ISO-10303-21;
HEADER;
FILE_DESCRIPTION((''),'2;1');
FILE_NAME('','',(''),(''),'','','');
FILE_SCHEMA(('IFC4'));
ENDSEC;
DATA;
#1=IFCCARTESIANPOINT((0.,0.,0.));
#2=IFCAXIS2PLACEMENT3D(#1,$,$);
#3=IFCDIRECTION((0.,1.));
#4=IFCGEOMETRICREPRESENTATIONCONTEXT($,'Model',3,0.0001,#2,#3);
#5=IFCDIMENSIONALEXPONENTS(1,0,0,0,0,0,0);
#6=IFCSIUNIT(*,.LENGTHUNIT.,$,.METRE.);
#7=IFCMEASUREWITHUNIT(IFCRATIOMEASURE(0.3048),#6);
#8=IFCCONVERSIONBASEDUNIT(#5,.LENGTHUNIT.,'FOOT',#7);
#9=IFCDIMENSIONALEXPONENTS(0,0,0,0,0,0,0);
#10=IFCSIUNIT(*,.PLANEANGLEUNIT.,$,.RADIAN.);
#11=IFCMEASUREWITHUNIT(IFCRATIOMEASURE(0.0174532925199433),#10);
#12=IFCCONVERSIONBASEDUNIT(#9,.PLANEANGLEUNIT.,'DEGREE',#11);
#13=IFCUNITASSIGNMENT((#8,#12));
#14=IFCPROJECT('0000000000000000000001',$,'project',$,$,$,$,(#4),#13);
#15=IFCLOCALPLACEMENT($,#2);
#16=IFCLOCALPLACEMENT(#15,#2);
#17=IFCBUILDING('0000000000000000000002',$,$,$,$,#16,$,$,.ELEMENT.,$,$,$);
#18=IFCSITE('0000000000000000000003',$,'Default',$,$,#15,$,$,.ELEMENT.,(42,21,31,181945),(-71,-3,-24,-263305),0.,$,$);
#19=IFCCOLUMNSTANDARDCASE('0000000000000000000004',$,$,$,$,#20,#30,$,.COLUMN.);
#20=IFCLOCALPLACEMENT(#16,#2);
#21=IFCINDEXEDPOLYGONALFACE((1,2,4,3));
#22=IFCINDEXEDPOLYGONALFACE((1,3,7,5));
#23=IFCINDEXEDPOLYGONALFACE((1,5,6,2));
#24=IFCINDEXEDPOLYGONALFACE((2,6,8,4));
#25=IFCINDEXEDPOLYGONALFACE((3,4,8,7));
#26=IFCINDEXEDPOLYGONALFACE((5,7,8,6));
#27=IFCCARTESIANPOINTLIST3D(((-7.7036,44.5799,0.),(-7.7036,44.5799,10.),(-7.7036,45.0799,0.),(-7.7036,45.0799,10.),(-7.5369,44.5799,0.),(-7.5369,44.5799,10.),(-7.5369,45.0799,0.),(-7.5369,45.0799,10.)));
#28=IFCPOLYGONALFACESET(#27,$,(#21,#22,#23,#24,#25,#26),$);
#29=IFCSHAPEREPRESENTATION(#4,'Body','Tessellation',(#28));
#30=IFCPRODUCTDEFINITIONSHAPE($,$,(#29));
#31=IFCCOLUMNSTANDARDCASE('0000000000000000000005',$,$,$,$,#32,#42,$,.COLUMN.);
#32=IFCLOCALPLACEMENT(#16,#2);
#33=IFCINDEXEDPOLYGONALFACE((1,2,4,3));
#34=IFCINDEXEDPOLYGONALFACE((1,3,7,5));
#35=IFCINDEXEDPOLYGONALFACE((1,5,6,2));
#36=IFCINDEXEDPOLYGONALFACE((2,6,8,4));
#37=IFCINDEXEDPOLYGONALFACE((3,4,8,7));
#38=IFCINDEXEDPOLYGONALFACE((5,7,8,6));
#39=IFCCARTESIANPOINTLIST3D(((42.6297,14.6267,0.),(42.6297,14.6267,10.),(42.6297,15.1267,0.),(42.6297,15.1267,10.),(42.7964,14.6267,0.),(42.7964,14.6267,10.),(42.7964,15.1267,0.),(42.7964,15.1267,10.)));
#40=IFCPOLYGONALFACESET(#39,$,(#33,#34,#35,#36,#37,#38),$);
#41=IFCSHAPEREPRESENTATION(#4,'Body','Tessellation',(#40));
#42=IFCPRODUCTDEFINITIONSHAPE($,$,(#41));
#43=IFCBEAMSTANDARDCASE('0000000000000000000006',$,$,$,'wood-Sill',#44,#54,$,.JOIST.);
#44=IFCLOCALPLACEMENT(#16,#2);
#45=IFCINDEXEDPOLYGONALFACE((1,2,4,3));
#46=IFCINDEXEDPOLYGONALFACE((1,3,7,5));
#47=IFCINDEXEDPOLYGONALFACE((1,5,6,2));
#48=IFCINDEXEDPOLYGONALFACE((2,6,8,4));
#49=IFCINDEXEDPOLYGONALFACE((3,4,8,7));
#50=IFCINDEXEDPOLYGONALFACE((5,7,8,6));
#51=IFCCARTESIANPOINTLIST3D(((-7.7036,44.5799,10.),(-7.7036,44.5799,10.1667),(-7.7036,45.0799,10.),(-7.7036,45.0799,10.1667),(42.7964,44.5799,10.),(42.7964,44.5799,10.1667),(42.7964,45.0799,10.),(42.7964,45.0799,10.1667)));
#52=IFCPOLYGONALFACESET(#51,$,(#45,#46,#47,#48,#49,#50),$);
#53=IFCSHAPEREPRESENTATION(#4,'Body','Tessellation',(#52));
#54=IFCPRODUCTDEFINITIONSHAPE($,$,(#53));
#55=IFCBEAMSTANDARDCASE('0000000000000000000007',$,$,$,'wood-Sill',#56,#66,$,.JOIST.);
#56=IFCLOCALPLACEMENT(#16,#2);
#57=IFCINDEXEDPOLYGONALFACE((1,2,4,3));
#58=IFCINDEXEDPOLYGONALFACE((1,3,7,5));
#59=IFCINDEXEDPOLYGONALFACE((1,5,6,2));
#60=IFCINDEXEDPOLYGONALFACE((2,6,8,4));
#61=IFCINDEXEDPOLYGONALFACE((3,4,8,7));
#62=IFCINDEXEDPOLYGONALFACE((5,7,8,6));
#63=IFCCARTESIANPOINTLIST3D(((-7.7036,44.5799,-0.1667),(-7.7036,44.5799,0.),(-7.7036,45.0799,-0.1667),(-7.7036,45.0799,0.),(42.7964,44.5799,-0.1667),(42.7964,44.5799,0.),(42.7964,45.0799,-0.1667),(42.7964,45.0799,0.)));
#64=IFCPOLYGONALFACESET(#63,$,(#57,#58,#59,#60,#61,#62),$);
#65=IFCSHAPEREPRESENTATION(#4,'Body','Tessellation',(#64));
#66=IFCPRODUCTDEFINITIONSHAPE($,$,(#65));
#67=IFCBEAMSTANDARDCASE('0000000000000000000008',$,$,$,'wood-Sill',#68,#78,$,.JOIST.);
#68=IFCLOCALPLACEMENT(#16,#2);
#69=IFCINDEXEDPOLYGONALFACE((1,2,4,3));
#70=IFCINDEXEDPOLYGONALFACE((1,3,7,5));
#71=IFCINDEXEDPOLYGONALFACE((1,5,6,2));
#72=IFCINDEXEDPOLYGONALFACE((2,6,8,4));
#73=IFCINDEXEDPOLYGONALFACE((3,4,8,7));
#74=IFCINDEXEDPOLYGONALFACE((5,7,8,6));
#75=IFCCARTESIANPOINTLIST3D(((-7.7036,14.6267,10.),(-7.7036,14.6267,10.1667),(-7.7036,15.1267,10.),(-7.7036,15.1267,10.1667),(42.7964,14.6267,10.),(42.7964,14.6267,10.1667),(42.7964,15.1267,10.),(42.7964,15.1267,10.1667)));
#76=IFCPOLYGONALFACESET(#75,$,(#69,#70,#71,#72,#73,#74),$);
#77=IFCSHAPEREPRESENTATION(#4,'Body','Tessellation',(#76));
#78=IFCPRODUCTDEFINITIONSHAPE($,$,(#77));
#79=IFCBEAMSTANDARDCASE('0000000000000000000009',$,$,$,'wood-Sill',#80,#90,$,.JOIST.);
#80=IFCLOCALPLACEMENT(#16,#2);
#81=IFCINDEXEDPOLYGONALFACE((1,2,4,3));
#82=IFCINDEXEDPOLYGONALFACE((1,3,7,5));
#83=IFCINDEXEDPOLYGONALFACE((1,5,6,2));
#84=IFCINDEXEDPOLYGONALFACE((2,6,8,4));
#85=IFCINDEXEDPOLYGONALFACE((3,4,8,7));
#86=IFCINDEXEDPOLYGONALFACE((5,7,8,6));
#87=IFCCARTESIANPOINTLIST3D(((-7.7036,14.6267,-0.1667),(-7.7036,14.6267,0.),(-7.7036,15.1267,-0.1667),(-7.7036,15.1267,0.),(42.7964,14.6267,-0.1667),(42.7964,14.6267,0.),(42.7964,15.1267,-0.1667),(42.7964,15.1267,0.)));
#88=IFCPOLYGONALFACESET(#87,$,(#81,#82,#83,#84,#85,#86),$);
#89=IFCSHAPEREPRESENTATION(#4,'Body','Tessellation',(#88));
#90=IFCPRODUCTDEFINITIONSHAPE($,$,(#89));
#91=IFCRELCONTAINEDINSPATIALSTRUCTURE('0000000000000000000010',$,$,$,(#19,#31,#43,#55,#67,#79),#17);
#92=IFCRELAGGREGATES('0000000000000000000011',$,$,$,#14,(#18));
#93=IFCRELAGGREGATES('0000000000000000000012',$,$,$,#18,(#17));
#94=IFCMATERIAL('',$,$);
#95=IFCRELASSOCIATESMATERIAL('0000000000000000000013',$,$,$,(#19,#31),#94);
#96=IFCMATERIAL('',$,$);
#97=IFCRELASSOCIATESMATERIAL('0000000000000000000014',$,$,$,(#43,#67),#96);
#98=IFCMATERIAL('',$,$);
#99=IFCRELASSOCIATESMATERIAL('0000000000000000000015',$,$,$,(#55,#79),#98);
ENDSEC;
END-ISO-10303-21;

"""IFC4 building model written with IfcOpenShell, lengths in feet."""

from ifc_helpers import new_model, entity, si_unit, converted_unit, direction, frame, origin, place, context, project, spatial, rectangle, extrude, material, element, save


model = new_model("IFC4")

# Units and contexts
model_context = context("Model", 3, precision=0.0001, world=origin(), true_north=direction((0.0, 1.0)))
ifc_project = project(units=[converted_unit("LENGTHUNIT", "FOOT", entity("IfcRatioMeasure", 0.3048), si_unit("LENGTHUNIT", "METRE"), dimensions=[1, 0, 0, 0, 0, 0, 0]), converted_unit("PLANEANGLEUNIT", "DEGREE", entity("IfcRatioMeasure", 0.0174532925199433), si_unit("PLANEANGLEUNIT", "RADIAN"), dimensions=[0, 0, 0, 0, 0, 0, 0])], contexts=[model_context])

# Site, building
site_placement = place(None, origin())
site = spatial("IfcSite", under=ifc_project, at=site_placement, Name="Default", CompositionType="ELEMENT", RefLatitude=(42, 21, 31, 181945), RefLongitude=(-71, -3, -24, -263305), RefElevation=0.0)
building_placement = place(site_placement, origin())
building = spatial("IfcBuilding", under=site, at=building_placement, CompositionType="ELEMENT")

# Columns
ifc_material_1 = material(Name="")
placement_1 = place(building_placement, origin())
placement_2 = place(placement_1, frame((-7.7036, 44.8299, 0.0)))
for number, where, z_axis, x_axis in (
    (1, (0.0833, 0.0, 0.0), (0.0, 0.0, 1.0), (1.0, 0.0, 0.0)),
):
    element("IfcColumnStandardCase", number, at=place(placement_2, frame(where, z_axis=z_axis, x_axis=x_axis)), inside=building, material=ifc_material_1, PredefinedType="COLUMN", context=model_context, shape_type="SweptSolid", body=[
        extrude(rectangle(XDim=0.1667, YDim=0.5), origin(), (0.0, 0.0, 1.0), 10.0),
    ])
placement_3 = place(placement_1, frame((42.7964, 14.8767, 0.0), z_axis=(0.0, 0.0, 1.0), x_axis=(-1.0, 0.0, 0.0)))
for number, where, z_axis, x_axis in (
    (2, (0.0833, 0.0, 0.0), (0.0, 0.0, 1.0), (1.0, 0.0, 0.0)),
):
    element("IfcColumnStandardCase", number, at=place(placement_3, frame(where, z_axis=z_axis, x_axis=x_axis)), inside=building, material=ifc_material_1, PredefinedType="COLUMN", context=model_context, shape_type="SweptSolid", body=[
        extrude(rectangle(XDim=0.1667, YDim=0.5), origin(), (0.0, 0.0, 1.0), 10.0),
    ])

# Beams
ifc_material_2 = material(Name="")
beam_1_placement = place(placement_2, frame((25.25, 0.0, 10.0), z_axis=(0.0, 0.0, 1.0), x_axis=(1.0, 0.0, 0.0)))
element("IfcBeamStandardCase", 3, at=beam_1_placement, inside=building, material=ifc_material_2, ObjectType="wood-Sill", PredefinedType="JOIST", context=model_context, shape_type="SweptSolid", body=[
    extrude(rectangle(XDim=50.5, YDim=0.5), origin(), (0.0, 0.0, 1.0), 0.1667),
])
ifc_material_3 = material(Name="")
beam_2_placement = place(placement_2, frame((25.25, 0.0, -0.1667), z_axis=(0.0, 0.0, 1.0), x_axis=(1.0, 0.0, 0.0)))
element("IfcBeamStandardCase", 4, at=beam_2_placement, inside=building, material=ifc_material_3, ObjectType="wood-Sill", PredefinedType="JOIST", context=model_context, shape_type="SweptSolid", body=[
    extrude(rectangle(XDim=50.5, YDim=0.5), origin(), (0.0, 0.0, 1.0), 0.1667),
])
beam_3_placement = place(placement_3, frame((25.25, 0.0, 10.0), z_axis=(0.0, 0.0, 1.0), x_axis=(1.0, 0.0, 0.0)))
element("IfcBeamStandardCase", 5, at=beam_3_placement, inside=building, material=ifc_material_2, ObjectType="wood-Sill", PredefinedType="JOIST", context=model_context, shape_type="SweptSolid", body=[
    extrude(rectangle(XDim=50.5, YDim=0.5), origin(), (0.0, 0.0, 1.0), 0.1667),
])
beam_4_placement = place(placement_3, frame((25.25, 0.0, -0.1667), z_axis=(0.0, 0.0, 1.0), x_axis=(1.0, 0.0, 0.0)))
element("IfcBeamStandardCase", 6, at=beam_4_placement, inside=building, material=ifc_material_3, ObjectType="wood-Sill", PredefinedType="JOIST", context=model_context, shape_type="SweptSolid", body=[
    extrude(rectangle(XDim=50.5, YDim=0.5), origin(), (0.0, 0.0, 1.0), 0.1667),
])

save(model, "model.ifc")
